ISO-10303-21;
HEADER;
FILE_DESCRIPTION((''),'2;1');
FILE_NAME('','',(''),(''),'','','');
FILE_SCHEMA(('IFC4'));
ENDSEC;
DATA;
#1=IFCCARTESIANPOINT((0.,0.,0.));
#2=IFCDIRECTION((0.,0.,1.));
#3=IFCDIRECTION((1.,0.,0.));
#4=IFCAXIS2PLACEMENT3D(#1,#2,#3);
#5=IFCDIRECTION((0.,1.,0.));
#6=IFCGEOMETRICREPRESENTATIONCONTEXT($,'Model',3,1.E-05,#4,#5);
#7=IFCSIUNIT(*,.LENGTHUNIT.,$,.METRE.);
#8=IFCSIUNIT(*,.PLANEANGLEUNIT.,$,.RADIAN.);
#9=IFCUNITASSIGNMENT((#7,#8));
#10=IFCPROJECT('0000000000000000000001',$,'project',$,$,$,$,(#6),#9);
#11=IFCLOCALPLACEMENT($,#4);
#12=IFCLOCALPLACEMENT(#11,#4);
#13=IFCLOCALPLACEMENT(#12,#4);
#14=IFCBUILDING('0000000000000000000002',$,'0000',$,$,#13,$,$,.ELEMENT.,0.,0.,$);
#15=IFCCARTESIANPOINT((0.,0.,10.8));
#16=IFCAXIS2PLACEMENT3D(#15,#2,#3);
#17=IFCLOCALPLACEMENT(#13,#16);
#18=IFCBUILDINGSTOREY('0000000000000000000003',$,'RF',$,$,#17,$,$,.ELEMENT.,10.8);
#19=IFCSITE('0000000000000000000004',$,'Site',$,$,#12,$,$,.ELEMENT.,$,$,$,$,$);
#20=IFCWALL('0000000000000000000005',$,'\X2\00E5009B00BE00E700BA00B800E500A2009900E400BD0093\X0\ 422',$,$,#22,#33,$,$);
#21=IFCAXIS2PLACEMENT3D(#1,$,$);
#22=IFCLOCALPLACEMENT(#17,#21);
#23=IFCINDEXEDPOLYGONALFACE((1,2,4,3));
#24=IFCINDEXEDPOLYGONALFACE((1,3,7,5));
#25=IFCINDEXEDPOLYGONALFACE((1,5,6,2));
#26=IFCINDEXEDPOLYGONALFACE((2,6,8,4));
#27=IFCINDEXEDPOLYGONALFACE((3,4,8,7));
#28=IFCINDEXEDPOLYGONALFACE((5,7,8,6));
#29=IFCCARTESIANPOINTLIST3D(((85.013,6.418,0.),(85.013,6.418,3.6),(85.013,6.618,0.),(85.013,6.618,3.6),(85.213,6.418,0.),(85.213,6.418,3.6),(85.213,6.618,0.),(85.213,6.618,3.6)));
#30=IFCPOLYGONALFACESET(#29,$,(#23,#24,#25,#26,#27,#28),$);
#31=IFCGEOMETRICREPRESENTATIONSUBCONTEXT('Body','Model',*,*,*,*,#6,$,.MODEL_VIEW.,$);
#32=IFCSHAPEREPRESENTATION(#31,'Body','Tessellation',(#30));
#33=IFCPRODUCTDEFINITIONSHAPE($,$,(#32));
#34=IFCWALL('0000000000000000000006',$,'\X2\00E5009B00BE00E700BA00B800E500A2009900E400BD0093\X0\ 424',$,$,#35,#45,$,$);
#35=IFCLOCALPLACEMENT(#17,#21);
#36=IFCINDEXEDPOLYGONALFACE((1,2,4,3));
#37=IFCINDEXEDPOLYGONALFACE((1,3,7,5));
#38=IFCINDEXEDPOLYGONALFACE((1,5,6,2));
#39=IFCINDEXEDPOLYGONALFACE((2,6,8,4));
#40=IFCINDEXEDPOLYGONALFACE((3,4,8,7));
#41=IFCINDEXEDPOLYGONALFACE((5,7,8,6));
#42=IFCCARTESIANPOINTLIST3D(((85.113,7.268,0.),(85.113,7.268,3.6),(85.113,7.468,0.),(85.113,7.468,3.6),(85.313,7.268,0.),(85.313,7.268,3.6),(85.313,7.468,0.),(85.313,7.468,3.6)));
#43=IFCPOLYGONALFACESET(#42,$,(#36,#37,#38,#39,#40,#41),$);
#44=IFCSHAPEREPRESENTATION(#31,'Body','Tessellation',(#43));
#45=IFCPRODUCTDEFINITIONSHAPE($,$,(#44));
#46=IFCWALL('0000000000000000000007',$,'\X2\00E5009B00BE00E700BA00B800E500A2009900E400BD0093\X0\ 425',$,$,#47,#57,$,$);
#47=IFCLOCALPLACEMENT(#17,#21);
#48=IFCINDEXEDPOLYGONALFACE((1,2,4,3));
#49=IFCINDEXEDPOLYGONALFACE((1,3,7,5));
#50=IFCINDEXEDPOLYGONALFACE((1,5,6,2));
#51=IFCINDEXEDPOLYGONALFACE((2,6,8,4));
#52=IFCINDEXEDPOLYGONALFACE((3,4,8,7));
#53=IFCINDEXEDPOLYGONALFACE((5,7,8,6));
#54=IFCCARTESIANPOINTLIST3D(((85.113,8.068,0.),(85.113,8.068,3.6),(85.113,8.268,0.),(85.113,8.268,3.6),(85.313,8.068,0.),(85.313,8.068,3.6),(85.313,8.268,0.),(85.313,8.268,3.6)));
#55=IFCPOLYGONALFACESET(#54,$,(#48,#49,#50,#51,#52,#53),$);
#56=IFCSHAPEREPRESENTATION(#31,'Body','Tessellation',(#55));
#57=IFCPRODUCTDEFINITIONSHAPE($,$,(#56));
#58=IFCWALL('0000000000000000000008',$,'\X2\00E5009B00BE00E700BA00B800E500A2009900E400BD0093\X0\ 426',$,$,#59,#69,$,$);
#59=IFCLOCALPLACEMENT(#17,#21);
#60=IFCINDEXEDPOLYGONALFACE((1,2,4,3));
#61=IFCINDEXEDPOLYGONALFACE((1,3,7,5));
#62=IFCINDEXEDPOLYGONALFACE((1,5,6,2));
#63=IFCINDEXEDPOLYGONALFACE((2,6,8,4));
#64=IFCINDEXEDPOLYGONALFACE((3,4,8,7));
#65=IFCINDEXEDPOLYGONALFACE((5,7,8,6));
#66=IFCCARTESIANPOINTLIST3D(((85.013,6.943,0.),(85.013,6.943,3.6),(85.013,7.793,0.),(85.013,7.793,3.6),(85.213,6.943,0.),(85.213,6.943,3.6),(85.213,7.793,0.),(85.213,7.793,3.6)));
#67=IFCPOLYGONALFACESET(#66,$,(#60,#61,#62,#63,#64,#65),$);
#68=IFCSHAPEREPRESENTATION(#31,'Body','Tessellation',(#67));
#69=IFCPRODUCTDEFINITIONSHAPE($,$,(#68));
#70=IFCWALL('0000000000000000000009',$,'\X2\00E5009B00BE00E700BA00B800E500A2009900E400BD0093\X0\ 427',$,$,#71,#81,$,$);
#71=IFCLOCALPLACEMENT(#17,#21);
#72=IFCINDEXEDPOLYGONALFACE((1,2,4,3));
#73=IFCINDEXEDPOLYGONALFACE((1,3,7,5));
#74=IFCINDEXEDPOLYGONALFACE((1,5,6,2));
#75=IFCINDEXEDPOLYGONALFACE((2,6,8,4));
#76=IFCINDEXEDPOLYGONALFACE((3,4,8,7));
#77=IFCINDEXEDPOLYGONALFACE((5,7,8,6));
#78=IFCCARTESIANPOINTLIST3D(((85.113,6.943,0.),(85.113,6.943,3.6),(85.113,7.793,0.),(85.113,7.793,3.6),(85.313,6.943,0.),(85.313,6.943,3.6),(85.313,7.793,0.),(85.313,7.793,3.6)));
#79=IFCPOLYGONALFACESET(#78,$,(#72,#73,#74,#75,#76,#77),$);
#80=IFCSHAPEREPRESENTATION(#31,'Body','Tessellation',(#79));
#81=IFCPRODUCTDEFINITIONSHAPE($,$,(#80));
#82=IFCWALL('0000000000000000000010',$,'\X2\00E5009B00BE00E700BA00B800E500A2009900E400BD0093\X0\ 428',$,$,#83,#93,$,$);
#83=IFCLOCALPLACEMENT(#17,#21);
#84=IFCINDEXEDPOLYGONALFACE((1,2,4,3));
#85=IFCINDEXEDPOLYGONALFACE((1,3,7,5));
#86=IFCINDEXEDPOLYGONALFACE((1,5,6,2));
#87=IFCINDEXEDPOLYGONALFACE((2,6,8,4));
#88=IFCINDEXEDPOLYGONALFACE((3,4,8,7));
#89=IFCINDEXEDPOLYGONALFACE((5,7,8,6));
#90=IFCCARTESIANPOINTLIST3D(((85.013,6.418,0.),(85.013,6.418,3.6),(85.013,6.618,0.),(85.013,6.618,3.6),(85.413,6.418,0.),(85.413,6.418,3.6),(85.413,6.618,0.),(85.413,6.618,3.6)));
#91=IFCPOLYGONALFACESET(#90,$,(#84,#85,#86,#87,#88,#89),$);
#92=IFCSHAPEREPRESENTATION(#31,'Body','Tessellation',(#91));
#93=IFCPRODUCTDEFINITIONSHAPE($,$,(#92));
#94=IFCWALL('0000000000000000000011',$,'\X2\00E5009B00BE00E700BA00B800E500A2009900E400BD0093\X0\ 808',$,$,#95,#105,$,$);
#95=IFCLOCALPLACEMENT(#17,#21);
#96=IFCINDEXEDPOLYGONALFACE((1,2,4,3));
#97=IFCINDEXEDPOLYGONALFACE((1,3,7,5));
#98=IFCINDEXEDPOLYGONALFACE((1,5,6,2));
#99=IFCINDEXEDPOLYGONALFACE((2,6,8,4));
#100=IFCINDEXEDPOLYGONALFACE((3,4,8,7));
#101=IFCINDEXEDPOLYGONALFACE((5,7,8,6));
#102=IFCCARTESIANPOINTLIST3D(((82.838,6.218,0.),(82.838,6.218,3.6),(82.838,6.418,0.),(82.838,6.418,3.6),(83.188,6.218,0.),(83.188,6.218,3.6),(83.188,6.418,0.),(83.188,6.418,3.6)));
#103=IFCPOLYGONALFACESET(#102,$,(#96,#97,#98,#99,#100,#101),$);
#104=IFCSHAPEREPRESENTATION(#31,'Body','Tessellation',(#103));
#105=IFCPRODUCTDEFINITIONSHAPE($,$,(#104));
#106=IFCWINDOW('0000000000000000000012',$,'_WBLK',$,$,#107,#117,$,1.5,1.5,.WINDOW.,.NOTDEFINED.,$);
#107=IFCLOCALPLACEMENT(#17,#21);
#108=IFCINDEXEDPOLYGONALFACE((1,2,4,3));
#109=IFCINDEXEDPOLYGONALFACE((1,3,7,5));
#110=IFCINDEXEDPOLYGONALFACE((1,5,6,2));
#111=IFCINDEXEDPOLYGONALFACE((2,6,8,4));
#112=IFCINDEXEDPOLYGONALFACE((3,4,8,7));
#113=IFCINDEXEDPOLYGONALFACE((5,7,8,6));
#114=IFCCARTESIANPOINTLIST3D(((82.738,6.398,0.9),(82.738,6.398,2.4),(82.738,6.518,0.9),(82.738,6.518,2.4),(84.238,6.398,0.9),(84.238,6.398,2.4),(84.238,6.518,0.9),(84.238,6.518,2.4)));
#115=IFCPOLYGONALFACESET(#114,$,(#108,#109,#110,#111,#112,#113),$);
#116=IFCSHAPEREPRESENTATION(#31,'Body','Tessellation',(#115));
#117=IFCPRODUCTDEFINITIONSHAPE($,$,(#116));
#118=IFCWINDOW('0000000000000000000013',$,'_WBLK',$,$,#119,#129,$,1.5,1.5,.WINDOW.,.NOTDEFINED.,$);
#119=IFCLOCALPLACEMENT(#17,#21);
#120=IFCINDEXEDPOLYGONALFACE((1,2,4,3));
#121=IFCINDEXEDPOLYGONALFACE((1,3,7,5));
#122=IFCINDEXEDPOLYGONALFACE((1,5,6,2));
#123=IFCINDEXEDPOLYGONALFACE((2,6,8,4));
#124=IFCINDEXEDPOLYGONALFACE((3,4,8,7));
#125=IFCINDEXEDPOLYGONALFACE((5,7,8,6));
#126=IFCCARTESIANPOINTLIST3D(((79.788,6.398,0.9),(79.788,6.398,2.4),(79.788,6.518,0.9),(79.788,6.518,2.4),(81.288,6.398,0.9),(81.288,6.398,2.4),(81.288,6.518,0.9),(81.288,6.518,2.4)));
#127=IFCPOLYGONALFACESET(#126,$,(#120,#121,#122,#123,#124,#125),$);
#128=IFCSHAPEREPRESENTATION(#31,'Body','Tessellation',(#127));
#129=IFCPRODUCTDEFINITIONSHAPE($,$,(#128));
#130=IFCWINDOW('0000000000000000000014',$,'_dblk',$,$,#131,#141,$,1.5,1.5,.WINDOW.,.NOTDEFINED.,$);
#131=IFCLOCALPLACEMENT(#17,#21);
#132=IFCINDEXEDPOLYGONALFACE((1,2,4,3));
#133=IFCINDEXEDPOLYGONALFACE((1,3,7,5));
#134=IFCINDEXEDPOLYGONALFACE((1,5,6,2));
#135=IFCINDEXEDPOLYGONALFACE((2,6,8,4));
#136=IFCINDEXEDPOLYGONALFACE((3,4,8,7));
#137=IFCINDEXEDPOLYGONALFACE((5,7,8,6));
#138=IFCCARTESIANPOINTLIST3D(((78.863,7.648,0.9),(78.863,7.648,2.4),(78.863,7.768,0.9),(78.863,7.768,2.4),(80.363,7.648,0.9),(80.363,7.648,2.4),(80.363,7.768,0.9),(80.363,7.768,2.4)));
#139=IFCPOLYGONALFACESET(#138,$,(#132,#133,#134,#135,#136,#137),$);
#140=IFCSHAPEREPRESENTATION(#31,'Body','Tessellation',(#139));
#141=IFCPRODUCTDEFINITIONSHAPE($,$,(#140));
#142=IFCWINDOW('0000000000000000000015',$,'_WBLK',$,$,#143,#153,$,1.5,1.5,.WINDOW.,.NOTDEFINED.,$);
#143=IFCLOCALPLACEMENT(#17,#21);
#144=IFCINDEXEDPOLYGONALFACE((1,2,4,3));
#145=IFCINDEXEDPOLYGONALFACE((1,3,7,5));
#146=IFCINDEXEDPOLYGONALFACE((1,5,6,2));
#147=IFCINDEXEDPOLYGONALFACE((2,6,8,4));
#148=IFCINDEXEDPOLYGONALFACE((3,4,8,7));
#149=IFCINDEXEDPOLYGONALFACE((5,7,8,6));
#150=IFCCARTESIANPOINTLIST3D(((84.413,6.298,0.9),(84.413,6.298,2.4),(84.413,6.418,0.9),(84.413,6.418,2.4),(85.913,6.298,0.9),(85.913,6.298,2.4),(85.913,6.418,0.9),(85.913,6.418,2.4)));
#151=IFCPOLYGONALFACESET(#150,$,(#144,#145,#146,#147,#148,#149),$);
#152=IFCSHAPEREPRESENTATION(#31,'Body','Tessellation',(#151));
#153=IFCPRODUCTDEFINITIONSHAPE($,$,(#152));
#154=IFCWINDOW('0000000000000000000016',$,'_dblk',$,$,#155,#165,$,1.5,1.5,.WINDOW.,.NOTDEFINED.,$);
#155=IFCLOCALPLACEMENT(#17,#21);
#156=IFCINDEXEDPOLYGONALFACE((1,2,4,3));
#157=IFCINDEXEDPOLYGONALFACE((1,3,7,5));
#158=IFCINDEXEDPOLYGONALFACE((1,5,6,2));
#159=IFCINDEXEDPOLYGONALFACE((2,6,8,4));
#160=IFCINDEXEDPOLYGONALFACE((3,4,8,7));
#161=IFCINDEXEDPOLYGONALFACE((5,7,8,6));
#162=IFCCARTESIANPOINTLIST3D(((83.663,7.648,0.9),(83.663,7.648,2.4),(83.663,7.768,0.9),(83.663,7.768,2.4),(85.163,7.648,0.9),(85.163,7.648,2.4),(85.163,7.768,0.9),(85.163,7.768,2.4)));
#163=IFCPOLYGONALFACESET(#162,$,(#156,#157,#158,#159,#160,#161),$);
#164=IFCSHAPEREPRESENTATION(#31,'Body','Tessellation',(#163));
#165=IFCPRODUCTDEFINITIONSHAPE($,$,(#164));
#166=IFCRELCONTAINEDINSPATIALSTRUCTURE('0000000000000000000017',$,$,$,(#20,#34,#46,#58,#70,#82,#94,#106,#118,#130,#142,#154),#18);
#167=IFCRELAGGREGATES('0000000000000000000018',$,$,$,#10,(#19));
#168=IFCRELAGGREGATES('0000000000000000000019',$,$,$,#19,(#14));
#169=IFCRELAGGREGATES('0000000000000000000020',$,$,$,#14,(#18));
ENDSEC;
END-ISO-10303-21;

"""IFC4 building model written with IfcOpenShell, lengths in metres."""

from ifc_helpers import new_model, si_unit, direction, frame, frame_2d, origin_with_axes, place, context, subcontext, project, spatial, rectangle, extrude, element, save


model = new_model("IFC4")

# Units and contexts
model_context = context("Model", 3, precision=1e-05, world=origin_with_axes(), true_north=direction((0.0, 1.0, 0.0)))
body_context = subcontext(model_context, "Body", "Model", "MODEL_VIEW")
ifc_project = project(units=[si_unit("LENGTHUNIT", "METRE"), si_unit("PLANEANGLEUNIT", "RADIAN")], contexts=[model_context])

# Site, building, storey
placement = place(None, origin_with_axes())
site_placement = place(placement, origin_with_axes())
site = spatial("IfcSite", under=ifc_project, at=site_placement, Name="Site", CompositionType="ELEMENT")
building_placement = place(site_placement, origin_with_axes())
building = spatial("IfcBuilding", under=site, at=building_placement, Name="0000", CompositionType="ELEMENT", ElevationOfRefHeight=0.0, ElevationOfTerrain=0.0)
storey_placement = place(building_placement, frame((0.0, 0.0, 10.8), z_axis=(0.0, 0.0, 1.0), x_axis=(1.0, 0.0, 0.0)))
storey = spatial("IfcBuildingStorey", under=building, at=storey_placement, Name="RF", CompositionType="ELEMENT", Elevation=10.8)

# Walls
for number, where, z_axis, x_axis, name in (
    (1, (85.113, 6.518, 0.0), (0.0, 0.0, 1.0), (0.0, -1.0, 0.0), "å\u009b¾çº¸å¢\u0099ä½\u0093 422"),
    (2, (85.213, 7.368, 0.0), (0.0, 0.0, 1.0), (-1.0, 0.0, 0.0), "å\u009b¾çº¸å¢\u0099ä½\u0093 424"),
    (3, (85.213, 8.168, 0.0), (0.0, 0.0, 1.0), (-1.0, 0.0, 0.0), "å\u009b¾çº¸å¢\u0099ä½\u0093 425"),
):
    element("IfcWall", number, at=place(storey_placement, frame(where, z_axis=z_axis, x_axis=x_axis)), inside=storey, Name=name, context=body_context, shape_type="SweptSolid", body=[
        extrude(rectangle(XDim=0.2, YDim=0.2, at=frame_2d((0.0, 0.0), x_axis=(1.0, 0.0, 0.0))), frame((0.0, 0.0, 0.0), z_axis=(0.0, 0.0, 1.0)), (0.0, 0.0, 1.0), 3.6),
    ])
for number, where, z_axis, x_axis, name in (
    (4, (85.113, 7.368, 0.0), (0.0, 0.0, 1.0), (0.0, -1.0, 0.0), "å\u009b¾çº¸å¢\u0099ä½\u0093 426"),
    (5, (85.213, 7.368, 0.0), (0.0, 0.0, 1.0), (0.0, -1.0, 0.0), "å\u009b¾çº¸å¢\u0099ä½\u0093 427"),
):
    element("IfcWall", number, at=place(storey_placement, frame(where, z_axis=z_axis, x_axis=x_axis)), inside=storey, Name=name, context=body_context, shape_type="SweptSolid", body=[
        extrude(rectangle(XDim=0.85, YDim=0.2, at=frame_2d((0.0, 0.0), x_axis=(1.0, 0.0, 0.0))), frame((0.0, 0.0, 0.0), z_axis=(0.0, 0.0, 1.0)), (0.0, 0.0, 1.0), 3.6),
    ])
wall_1_placement = place(storey_placement, frame((85.213, 6.518, 0.0), z_axis=(0.0, 0.0, 1.0), x_axis=(1.0, 0.0, 0.0)))
element("IfcWall", 6, at=wall_1_placement, inside=storey, Name="å\u009b¾çº¸å¢\u0099ä½\u0093 428", context=body_context, shape_type="SweptSolid", body=[
    extrude(rectangle(XDim=0.4, YDim=0.2, at=frame_2d((0.0, 0.0), x_axis=(1.0, 0.0, 0.0))), frame((0.0, 0.0, 0.0), z_axis=(0.0, 0.0, 1.0)), (0.0, 0.0, 1.0), 3.6),
])
wall_2_placement = place(storey_placement, frame((83.013, 6.318, 0.0), z_axis=(0.0, 0.0, 1.0), x_axis=(1.0, 0.0, 0.0)))
element("IfcWall", 7, at=wall_2_placement, inside=storey, Name="å\u009b¾çº¸å¢\u0099ä½\u0093 808", context=body_context, shape_type="SweptSolid", body=[
    extrude(rectangle(XDim=0.35, YDim=0.2, at=frame_2d((0.0, 0.0), x_axis=(1.0, 0.0, 0.0))), frame((0.0, 0.0, 0.0), z_axis=(0.0, 0.0, 1.0)), (0.0, 0.0, 1.0), 3.6),
])

# Windows
for number, where, z_axis, x_axis, name in (
    (8, (83.488, 6.458, 0.9), (0.0, 0.0, 1.0), (1.0, 0.0, 0.0), "_WBLK"),
    (9, (80.538, 6.458, 0.9), (0.0, 0.0, 1.0), (1.0, 0.0, 0.0), "_WBLK"),
    (10, (79.613, 7.708, 0.9), (0.0, 0.0, 1.0), (1.0, 0.0, 0.0), "_dblk"),
    (11, (85.163, 6.358, 0.9), (0.0, 0.0, 1.0), (1.0, 0.0, 0.0), "_WBLK"),
    (12, (84.413, 7.708, 0.9), (0.0, 0.0, 1.0), (1.0, 0.0, 0.0), "_dblk"),
):
    element("IfcWindow", number, at=place(storey_placement, frame(where, z_axis=z_axis, x_axis=x_axis)), inside=storey, Name=name, OverallHeight=1.5, OverallWidth=1.5, PartitioningType="NOTDEFINED", PredefinedType="WINDOW", context=body_context, shape_type="SweptSolid", body=[
        extrude(rectangle(XDim=1.5, YDim=0.12, at=frame_2d((0.0, 0.0), x_axis=(1.0, 0.0, 0.0))), frame((0.0, 0.0, 0.0), z_axis=(0.0, 0.0, 1.0)), (0.0, 0.0, 1.0), 1.5),
    ])

save(model, "model.ifc")
